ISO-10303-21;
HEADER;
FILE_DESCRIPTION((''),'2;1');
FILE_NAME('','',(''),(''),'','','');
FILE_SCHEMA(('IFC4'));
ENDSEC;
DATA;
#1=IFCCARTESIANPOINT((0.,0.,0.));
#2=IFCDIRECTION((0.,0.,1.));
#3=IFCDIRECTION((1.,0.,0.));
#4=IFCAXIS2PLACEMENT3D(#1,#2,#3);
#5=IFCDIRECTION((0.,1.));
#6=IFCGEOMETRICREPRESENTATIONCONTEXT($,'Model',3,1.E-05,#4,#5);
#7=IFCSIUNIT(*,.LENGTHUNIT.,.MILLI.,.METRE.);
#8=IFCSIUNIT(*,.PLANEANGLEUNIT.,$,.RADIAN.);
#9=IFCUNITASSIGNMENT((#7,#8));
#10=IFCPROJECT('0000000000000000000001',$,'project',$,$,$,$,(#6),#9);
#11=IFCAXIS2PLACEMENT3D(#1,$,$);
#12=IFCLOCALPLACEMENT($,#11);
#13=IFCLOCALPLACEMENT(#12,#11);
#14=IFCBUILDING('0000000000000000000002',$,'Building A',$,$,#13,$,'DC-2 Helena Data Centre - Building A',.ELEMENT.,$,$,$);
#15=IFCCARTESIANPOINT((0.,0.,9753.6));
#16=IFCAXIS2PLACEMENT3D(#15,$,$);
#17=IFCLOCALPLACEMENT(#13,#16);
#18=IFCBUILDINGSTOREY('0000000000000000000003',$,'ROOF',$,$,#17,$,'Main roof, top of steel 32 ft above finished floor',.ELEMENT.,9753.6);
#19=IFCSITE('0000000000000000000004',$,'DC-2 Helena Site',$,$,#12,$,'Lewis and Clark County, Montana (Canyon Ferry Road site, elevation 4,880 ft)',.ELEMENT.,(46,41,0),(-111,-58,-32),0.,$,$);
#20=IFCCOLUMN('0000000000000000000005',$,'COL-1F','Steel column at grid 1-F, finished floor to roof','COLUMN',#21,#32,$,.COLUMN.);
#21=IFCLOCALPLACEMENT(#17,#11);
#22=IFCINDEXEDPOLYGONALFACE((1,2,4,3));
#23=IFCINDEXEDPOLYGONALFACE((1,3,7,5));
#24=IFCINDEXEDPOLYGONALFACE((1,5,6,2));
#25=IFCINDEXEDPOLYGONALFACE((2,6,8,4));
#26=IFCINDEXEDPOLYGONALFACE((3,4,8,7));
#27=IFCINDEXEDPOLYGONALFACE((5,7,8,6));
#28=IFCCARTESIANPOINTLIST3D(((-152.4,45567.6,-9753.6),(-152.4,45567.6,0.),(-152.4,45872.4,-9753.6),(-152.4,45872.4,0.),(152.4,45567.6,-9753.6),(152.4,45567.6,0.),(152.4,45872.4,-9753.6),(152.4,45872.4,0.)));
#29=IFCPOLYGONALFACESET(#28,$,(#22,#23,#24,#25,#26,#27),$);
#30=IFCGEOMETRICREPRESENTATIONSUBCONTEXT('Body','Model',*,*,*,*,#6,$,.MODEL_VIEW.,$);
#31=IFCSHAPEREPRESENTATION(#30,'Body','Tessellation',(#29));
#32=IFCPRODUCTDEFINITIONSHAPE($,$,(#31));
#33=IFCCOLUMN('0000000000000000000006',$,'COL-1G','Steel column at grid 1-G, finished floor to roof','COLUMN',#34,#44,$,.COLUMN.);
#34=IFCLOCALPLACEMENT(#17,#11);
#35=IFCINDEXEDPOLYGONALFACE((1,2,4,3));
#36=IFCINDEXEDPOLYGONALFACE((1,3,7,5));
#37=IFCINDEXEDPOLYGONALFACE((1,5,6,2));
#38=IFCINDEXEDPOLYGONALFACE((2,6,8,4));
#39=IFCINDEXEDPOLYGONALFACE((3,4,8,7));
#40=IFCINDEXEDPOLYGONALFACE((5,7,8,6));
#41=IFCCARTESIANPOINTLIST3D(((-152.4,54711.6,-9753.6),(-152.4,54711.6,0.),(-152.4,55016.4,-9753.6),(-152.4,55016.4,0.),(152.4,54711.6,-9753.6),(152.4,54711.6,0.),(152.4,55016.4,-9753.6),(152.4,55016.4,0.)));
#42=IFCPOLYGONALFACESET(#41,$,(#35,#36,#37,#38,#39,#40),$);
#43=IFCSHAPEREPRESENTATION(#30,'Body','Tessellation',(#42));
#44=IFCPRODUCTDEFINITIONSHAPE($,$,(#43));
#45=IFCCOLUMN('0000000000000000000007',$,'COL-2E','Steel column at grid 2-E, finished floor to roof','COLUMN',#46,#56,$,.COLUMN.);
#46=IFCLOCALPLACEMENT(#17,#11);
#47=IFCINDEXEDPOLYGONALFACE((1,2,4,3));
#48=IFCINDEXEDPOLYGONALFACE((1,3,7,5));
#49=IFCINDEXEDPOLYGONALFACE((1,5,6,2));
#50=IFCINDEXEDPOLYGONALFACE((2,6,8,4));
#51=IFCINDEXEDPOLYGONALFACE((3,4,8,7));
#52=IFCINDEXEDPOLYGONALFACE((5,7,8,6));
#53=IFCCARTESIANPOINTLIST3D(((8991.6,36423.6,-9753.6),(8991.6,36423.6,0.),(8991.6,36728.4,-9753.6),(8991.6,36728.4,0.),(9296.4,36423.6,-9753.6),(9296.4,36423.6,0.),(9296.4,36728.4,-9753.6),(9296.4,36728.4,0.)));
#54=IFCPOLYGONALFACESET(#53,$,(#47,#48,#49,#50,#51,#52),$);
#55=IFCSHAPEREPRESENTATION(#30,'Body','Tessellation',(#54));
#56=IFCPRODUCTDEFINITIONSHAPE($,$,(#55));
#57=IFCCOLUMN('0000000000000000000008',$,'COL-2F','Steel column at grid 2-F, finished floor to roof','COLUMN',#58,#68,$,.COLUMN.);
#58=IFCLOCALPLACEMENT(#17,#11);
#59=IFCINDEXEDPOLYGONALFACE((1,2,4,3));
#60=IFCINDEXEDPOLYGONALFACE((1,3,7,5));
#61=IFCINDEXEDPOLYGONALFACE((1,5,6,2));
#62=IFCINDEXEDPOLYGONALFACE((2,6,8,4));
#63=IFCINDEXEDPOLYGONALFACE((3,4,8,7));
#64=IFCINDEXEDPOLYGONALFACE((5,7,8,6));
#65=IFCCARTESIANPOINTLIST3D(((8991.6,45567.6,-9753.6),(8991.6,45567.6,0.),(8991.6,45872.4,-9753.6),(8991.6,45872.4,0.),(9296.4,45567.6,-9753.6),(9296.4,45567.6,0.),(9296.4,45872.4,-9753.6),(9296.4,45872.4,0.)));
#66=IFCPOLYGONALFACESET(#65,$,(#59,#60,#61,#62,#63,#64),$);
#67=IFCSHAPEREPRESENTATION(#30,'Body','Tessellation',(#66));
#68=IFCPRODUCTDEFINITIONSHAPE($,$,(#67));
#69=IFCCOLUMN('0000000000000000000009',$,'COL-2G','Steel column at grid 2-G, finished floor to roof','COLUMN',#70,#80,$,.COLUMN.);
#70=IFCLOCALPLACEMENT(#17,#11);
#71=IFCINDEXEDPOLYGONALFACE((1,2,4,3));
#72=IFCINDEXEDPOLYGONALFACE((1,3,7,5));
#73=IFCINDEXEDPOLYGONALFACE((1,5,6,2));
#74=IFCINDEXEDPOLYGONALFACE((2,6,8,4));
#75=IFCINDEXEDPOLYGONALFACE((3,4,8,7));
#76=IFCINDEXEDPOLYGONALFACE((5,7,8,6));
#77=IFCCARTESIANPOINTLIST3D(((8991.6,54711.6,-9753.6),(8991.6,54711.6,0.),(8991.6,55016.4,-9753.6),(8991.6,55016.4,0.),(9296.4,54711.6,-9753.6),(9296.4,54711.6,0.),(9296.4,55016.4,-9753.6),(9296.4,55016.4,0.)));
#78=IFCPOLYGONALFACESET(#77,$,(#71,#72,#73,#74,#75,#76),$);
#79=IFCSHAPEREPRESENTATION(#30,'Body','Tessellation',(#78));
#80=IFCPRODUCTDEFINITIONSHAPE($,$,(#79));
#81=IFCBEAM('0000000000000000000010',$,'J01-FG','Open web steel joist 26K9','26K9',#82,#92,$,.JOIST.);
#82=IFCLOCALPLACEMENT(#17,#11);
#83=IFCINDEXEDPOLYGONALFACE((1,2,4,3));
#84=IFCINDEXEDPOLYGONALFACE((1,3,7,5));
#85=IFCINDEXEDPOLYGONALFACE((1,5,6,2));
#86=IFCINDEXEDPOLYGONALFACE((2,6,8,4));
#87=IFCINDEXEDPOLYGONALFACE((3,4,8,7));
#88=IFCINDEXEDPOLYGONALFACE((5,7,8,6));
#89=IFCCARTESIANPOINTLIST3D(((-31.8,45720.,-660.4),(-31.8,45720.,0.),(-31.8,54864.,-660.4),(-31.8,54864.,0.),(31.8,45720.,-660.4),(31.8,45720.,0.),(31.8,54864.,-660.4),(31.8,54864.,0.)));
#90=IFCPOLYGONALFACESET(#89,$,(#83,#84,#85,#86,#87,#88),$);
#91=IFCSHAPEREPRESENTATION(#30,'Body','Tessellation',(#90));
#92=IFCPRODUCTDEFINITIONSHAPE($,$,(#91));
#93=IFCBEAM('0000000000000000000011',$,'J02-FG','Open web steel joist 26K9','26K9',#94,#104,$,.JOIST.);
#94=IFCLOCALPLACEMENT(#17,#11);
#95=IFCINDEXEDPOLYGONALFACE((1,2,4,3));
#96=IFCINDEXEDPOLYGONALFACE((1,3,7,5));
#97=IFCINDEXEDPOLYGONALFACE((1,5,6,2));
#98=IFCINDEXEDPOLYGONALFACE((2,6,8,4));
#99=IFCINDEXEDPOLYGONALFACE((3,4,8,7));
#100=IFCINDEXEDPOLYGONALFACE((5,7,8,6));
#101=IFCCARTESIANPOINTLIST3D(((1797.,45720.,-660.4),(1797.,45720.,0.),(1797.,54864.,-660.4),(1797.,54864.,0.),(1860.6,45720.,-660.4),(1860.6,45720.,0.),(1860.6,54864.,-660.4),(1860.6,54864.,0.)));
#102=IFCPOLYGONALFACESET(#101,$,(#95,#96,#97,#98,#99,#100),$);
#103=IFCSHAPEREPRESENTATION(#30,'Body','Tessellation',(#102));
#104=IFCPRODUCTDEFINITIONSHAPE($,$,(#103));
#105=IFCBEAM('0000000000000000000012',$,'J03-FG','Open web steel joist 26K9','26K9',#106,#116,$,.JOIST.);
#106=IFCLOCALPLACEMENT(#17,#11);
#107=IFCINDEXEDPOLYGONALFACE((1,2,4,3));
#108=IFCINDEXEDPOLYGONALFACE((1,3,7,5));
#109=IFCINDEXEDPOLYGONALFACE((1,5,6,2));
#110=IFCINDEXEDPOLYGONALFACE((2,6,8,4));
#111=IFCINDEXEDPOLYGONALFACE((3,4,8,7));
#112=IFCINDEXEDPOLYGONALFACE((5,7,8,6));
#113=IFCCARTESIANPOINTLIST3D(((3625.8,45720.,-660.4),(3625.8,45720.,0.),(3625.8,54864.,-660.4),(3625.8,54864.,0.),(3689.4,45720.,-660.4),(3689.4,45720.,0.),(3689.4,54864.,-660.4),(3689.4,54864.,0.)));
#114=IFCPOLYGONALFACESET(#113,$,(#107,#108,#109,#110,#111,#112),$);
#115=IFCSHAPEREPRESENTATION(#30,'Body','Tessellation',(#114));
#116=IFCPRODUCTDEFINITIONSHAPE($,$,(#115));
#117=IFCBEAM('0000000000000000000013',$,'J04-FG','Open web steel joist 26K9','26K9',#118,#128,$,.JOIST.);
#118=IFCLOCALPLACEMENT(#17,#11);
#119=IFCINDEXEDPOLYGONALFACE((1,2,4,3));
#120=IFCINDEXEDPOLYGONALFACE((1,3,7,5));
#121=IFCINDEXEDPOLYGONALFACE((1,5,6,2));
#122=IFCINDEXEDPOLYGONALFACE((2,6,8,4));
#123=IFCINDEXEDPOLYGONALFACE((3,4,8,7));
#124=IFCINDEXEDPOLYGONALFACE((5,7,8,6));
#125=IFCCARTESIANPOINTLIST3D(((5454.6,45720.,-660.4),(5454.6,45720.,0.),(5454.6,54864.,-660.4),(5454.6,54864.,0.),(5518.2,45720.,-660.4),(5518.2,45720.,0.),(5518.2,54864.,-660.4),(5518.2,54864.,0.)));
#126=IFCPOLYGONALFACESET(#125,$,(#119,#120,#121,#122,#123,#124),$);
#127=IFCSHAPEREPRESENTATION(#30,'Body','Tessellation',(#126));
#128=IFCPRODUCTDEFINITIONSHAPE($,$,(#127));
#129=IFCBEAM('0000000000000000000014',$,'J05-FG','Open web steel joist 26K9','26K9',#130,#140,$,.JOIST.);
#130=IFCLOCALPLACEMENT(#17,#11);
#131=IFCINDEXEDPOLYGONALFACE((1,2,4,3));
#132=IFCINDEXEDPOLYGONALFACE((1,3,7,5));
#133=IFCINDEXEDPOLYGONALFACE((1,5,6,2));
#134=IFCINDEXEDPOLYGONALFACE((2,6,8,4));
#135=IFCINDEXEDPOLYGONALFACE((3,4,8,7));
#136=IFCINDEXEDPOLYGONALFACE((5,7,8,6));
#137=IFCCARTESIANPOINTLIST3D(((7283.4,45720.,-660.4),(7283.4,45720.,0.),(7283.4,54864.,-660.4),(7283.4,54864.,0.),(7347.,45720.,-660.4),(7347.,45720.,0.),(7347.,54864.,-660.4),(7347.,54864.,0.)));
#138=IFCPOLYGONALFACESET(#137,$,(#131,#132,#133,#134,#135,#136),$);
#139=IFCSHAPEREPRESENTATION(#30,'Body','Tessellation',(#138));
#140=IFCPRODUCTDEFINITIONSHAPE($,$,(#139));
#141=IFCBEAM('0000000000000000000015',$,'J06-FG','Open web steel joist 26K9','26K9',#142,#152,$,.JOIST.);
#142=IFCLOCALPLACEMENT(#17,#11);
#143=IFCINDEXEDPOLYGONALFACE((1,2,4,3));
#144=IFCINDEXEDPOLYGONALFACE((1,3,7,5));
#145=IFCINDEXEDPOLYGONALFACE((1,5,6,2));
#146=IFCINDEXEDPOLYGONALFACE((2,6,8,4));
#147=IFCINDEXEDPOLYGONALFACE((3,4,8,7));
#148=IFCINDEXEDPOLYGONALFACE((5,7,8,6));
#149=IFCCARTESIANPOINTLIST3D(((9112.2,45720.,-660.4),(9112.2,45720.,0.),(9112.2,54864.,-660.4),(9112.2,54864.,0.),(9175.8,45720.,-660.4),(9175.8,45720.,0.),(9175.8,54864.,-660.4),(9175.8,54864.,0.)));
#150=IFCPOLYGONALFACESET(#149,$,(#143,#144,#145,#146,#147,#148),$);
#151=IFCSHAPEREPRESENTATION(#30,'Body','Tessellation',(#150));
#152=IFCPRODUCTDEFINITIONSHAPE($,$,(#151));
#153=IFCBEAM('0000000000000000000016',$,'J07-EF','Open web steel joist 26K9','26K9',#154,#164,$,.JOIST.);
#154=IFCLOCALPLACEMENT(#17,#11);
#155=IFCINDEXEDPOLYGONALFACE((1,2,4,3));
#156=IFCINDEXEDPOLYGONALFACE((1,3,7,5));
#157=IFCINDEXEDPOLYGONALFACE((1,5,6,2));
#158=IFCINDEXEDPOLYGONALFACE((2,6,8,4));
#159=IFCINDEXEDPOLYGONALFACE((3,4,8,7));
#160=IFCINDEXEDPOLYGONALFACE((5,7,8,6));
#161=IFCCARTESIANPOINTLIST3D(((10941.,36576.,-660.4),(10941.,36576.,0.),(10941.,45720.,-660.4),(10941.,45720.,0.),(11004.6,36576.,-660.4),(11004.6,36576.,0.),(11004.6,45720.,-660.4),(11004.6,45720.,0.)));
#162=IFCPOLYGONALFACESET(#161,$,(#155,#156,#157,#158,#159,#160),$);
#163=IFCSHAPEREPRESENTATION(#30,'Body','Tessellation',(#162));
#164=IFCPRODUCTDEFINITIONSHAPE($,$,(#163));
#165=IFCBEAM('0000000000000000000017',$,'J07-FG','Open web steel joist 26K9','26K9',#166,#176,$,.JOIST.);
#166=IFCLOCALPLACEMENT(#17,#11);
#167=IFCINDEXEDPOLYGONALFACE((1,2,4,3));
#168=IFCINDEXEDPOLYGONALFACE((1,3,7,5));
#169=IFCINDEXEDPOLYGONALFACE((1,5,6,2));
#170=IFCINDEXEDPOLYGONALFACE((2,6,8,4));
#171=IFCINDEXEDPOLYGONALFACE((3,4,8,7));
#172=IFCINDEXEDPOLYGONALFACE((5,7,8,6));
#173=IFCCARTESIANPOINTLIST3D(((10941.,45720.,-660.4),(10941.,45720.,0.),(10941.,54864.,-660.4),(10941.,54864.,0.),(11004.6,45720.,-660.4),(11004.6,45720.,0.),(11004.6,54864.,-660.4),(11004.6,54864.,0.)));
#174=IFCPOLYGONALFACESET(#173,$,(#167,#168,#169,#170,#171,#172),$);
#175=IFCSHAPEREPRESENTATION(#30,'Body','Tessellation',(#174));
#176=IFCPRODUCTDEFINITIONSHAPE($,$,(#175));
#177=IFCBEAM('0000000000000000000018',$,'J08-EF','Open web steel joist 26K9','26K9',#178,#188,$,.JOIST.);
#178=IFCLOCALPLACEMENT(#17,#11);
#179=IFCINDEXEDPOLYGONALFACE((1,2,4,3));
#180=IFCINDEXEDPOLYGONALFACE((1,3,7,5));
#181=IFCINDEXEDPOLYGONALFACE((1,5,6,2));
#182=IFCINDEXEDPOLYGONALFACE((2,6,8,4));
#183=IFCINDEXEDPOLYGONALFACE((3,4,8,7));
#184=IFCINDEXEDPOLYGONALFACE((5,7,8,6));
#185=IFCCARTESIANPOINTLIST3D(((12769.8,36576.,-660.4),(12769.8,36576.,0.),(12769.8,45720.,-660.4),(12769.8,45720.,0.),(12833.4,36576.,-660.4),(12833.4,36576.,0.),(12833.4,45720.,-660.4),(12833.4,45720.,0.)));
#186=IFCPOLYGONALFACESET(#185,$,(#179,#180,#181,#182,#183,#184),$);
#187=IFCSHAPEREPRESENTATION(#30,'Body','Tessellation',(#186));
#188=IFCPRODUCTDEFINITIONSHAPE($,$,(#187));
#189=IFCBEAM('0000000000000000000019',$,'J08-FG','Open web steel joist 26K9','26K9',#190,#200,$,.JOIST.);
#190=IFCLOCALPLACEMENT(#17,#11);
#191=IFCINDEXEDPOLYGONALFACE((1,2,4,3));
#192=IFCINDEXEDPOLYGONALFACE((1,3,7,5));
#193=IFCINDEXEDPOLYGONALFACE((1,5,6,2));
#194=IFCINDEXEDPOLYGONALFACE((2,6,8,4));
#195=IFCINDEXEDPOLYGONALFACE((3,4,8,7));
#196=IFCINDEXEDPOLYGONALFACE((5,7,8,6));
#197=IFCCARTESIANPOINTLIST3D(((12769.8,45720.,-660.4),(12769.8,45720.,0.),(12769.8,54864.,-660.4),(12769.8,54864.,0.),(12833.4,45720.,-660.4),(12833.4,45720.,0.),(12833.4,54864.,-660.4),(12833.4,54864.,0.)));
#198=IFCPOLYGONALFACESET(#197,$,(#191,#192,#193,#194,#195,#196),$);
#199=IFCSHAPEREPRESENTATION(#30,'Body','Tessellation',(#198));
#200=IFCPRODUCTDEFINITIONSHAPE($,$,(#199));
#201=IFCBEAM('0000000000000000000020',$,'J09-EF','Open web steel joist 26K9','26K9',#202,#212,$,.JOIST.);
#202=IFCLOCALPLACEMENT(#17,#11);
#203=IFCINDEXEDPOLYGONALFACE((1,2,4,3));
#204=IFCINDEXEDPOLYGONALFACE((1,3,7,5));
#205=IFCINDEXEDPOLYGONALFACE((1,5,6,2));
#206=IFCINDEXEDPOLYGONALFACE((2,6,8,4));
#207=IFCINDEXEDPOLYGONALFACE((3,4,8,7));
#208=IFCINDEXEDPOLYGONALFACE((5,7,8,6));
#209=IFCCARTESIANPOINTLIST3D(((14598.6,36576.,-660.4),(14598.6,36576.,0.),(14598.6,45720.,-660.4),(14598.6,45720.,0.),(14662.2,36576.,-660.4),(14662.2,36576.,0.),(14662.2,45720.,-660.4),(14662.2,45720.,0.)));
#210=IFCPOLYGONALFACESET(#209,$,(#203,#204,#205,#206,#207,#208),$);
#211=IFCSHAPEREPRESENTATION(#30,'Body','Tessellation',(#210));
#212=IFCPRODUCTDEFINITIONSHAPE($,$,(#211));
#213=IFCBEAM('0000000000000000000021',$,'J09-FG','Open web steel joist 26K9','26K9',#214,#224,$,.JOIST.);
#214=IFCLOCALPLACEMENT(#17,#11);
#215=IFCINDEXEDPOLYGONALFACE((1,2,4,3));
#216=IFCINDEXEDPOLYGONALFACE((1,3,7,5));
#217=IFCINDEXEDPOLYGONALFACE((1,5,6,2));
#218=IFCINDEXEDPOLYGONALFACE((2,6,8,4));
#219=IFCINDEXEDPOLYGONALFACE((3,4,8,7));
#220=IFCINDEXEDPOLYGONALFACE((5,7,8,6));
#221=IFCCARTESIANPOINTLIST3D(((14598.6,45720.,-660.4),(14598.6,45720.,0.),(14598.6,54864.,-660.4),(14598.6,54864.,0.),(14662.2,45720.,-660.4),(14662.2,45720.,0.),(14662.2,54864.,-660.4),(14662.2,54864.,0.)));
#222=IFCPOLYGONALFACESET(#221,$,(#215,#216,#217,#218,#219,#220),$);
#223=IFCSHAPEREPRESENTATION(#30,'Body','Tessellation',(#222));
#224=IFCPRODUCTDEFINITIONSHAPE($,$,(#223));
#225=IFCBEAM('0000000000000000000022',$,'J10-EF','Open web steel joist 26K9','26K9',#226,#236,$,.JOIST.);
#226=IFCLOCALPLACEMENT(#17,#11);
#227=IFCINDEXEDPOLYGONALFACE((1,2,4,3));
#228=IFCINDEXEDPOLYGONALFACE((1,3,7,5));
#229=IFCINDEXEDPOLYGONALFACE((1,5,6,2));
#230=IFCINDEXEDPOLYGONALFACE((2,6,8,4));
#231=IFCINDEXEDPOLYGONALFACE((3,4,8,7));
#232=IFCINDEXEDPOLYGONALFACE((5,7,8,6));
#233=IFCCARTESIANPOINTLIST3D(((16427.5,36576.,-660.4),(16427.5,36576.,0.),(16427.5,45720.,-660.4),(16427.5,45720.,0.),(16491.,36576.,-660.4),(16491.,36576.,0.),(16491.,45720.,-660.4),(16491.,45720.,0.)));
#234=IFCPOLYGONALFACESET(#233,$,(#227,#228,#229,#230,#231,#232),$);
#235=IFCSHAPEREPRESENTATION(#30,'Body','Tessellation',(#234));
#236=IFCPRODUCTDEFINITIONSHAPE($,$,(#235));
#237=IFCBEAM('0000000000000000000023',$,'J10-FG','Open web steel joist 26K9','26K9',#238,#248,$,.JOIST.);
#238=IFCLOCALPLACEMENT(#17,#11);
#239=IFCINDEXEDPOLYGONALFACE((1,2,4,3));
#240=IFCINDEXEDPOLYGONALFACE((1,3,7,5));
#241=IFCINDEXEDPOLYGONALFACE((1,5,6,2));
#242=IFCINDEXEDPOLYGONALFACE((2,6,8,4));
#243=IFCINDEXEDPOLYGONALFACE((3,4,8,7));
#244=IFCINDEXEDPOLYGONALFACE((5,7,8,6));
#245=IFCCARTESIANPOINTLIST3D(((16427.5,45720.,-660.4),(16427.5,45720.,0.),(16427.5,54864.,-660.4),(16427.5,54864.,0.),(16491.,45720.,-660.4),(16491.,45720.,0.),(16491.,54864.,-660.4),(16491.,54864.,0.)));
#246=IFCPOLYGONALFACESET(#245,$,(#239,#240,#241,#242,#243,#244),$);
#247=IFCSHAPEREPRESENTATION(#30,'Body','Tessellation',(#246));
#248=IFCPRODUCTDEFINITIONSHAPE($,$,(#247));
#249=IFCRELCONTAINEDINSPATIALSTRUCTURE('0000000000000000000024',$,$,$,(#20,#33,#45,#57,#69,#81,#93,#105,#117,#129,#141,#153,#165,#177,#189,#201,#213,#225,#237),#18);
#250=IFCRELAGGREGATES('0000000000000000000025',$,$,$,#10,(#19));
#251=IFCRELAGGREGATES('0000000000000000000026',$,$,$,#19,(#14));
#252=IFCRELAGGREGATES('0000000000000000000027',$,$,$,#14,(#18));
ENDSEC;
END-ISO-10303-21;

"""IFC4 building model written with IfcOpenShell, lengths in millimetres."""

from ifc_helpers import new_model, si_unit, direction, frame, origin, origin_with_axes, origin_2d, place, context, subcontext, project, spatial, rectangle, extrude, element, save


model = new_model("IFC4")

# Units and contexts
model_context = context("Model", 3, precision=1e-05, world=origin_with_axes(), true_north=direction((0.0, 1.0)))
body_context = subcontext(model_context, "Body", "Model", "MODEL_VIEW")
ifc_project = project(units=[si_unit("LENGTHUNIT", "METRE", prefix="MILLI"), si_unit("PLANEANGLEUNIT", "RADIAN")], contexts=[model_context])

# Site, building, storey
site_placement = place(None, origin())
site = spatial("IfcSite", under=ifc_project, at=site_placement, Name="DC-2 Helena Site", LongName="Lewis and Clark County, Montana (Canyon Ferry Road site, elevation 4,880 ft)", CompositionType="ELEMENT", RefLatitude=(46, 41, 0), RefLongitude=(-111, -58, -32), RefElevation=0.0)
building_placement = place(site_placement, origin())
building = spatial("IfcBuilding", under=site, at=building_placement, Name="Building A", LongName="DC-2 Helena Data Centre - Building A", CompositionType="ELEMENT")
storey_placement = place(building_placement, frame((0.0, 0.0, 9753.6)))
storey = spatial("IfcBuildingStorey", under=building, at=storey_placement, Name="ROOF", LongName="Main roof, top of steel 32 ft above finished floor", CompositionType="ELEMENT", Elevation=9753.6)

# Columns
placement_1 = place(storey_placement, frame((0.0, 45720.0, -9753.6)))
element("IfcColumn", 1, at=placement_1, inside=storey, Name="COL-1F", Description="Steel column at grid 1-F, finished floor to roof", ObjectType="COLUMN", PredefinedType="COLUMN", context=body_context, shape_type="SweptSolid", body=[
    extrude(rectangle(XDim=304.8, YDim=304.8, at=origin_2d()), origin(), (0.0, 0.0, 1.0), 9753.6),
])
for number, where, name, description in (
    (2, (0.0, 54864.0, -9753.6), "COL-1G", "Steel column at grid 1-G, finished floor to roof"),
    (3, (9144.0, 36576.0, -9753.6), "COL-2E", "Steel column at grid 2-E, finished floor to roof"),
    (4, (9144.0, 45720.0, -9753.6), "COL-2F", "Steel column at grid 2-F, finished floor to roof"),
    (5, (9144.0, 54864.0, -9753.6), "COL-2G", "Steel column at grid 2-G, finished floor to roof"),
):
    element("IfcColumn", number, at=place(storey_placement, frame(where)), inside=storey, Name=name, Description=description, ObjectType="COLUMN", PredefinedType="COLUMN", context=body_context, shape_type="SweptSolid", body=[
        extrude(rectangle(XDim=304.8, YDim=304.8, at=origin_2d()), origin(), (0.0, 0.0, 1.0), 9753.6),
    ])

# Beams
placement_2 = place(storey_placement, frame((0.0, 45720.0, 0.0)))
element("IfcBeam", 6, at=placement_2, inside=storey, Name="J01-FG", Description="Open web steel joist 26K9", ObjectType="26K9", PredefinedType="JOIST", context=body_context, shape_type="SweptSolid", body=[
    extrude(rectangle(XDim=63.5, YDim=660.4, at=origin_2d()), frame((0.0, 0.0, -330.2), z_axis=(0.0, 1.0, 0.0), x_axis=(1.0, 0.0, 0.0)), (0.0, 0.0, 1.0), 9144.0),
])
for number, where, name in (
    (7, (1828.8, 45720.0, 0.0), "J02-FG"),
    (8, (3657.6, 45720.0, 0.0), "J03-FG"),
    (9, (5486.4, 45720.0, 0.0), "J04-FG"),
    (10, (7315.2, 45720.0, 0.0), "J05-FG"),
):
    element("IfcBeam", number, at=place(storey_placement, frame(where)), inside=storey, Name=name, Description="Open web steel joist 26K9", ObjectType="26K9", PredefinedType="JOIST", context=body_context, shape_type="SweptSolid", body=[
        extrude(rectangle(XDim=63.5, YDim=660.4, at=origin_2d()), frame((0.0, 0.0, -330.2), z_axis=(0.0, 1.0, 0.0), x_axis=(1.0, 0.0, 0.0)), (0.0, 0.0, 1.0), 9144.0),
    ])
placement_3 = place(storey_placement, frame((9144.0, 45720.0, 0.0)))
element("IfcBeam", 11, at=placement_3, inside=storey, Name="J06-FG", Description="Open web steel joist 26K9", ObjectType="26K9", PredefinedType="JOIST", context=body_context, shape_type="SweptSolid", body=[
    extrude(rectangle(XDim=63.5, YDim=660.4, at=origin_2d()), frame((0.0, 0.0, -330.2), z_axis=(0.0, 1.0, 0.0), x_axis=(1.0, 0.0, 0.0)), (0.0, 0.0, 1.0), 9144.0),
])
for number, where, name in (
    (12, (10972.8, 36576.0, 0.0), "J07-EF"),
    (13, (10972.8, 45720.0, 0.0), "J07-FG"),
    (14, (12801.6, 36576.0, 0.0), "J08-EF"),
    (15, (12801.6, 45720.0, 0.0), "J08-FG"),
    (16, (14630.4, 36576.0, 0.0), "J09-EF"),
    (17, (14630.4, 45720.0, 0.0), "J09-FG"),
    (18, (16459.2, 36576.0, 0.0), "J10-EF"),
    (19, (16459.2, 45720.0, 0.0), "J10-FG"),
):
    element("IfcBeam", number, at=place(storey_placement, frame(where)), inside=storey, Name=name, Description="Open web steel joist 26K9", ObjectType="26K9", PredefinedType="JOIST", context=body_context, shape_type="SweptSolid", body=[
        extrude(rectangle(XDim=63.5, YDim=660.4, at=origin_2d()), frame((0.0, 0.0, -330.2), z_axis=(0.0, 1.0, 0.0), x_axis=(1.0, 0.0, 0.0)), (0.0, 0.0, 1.0), 9144.0),
    ])

save(model, "model.ifc")
